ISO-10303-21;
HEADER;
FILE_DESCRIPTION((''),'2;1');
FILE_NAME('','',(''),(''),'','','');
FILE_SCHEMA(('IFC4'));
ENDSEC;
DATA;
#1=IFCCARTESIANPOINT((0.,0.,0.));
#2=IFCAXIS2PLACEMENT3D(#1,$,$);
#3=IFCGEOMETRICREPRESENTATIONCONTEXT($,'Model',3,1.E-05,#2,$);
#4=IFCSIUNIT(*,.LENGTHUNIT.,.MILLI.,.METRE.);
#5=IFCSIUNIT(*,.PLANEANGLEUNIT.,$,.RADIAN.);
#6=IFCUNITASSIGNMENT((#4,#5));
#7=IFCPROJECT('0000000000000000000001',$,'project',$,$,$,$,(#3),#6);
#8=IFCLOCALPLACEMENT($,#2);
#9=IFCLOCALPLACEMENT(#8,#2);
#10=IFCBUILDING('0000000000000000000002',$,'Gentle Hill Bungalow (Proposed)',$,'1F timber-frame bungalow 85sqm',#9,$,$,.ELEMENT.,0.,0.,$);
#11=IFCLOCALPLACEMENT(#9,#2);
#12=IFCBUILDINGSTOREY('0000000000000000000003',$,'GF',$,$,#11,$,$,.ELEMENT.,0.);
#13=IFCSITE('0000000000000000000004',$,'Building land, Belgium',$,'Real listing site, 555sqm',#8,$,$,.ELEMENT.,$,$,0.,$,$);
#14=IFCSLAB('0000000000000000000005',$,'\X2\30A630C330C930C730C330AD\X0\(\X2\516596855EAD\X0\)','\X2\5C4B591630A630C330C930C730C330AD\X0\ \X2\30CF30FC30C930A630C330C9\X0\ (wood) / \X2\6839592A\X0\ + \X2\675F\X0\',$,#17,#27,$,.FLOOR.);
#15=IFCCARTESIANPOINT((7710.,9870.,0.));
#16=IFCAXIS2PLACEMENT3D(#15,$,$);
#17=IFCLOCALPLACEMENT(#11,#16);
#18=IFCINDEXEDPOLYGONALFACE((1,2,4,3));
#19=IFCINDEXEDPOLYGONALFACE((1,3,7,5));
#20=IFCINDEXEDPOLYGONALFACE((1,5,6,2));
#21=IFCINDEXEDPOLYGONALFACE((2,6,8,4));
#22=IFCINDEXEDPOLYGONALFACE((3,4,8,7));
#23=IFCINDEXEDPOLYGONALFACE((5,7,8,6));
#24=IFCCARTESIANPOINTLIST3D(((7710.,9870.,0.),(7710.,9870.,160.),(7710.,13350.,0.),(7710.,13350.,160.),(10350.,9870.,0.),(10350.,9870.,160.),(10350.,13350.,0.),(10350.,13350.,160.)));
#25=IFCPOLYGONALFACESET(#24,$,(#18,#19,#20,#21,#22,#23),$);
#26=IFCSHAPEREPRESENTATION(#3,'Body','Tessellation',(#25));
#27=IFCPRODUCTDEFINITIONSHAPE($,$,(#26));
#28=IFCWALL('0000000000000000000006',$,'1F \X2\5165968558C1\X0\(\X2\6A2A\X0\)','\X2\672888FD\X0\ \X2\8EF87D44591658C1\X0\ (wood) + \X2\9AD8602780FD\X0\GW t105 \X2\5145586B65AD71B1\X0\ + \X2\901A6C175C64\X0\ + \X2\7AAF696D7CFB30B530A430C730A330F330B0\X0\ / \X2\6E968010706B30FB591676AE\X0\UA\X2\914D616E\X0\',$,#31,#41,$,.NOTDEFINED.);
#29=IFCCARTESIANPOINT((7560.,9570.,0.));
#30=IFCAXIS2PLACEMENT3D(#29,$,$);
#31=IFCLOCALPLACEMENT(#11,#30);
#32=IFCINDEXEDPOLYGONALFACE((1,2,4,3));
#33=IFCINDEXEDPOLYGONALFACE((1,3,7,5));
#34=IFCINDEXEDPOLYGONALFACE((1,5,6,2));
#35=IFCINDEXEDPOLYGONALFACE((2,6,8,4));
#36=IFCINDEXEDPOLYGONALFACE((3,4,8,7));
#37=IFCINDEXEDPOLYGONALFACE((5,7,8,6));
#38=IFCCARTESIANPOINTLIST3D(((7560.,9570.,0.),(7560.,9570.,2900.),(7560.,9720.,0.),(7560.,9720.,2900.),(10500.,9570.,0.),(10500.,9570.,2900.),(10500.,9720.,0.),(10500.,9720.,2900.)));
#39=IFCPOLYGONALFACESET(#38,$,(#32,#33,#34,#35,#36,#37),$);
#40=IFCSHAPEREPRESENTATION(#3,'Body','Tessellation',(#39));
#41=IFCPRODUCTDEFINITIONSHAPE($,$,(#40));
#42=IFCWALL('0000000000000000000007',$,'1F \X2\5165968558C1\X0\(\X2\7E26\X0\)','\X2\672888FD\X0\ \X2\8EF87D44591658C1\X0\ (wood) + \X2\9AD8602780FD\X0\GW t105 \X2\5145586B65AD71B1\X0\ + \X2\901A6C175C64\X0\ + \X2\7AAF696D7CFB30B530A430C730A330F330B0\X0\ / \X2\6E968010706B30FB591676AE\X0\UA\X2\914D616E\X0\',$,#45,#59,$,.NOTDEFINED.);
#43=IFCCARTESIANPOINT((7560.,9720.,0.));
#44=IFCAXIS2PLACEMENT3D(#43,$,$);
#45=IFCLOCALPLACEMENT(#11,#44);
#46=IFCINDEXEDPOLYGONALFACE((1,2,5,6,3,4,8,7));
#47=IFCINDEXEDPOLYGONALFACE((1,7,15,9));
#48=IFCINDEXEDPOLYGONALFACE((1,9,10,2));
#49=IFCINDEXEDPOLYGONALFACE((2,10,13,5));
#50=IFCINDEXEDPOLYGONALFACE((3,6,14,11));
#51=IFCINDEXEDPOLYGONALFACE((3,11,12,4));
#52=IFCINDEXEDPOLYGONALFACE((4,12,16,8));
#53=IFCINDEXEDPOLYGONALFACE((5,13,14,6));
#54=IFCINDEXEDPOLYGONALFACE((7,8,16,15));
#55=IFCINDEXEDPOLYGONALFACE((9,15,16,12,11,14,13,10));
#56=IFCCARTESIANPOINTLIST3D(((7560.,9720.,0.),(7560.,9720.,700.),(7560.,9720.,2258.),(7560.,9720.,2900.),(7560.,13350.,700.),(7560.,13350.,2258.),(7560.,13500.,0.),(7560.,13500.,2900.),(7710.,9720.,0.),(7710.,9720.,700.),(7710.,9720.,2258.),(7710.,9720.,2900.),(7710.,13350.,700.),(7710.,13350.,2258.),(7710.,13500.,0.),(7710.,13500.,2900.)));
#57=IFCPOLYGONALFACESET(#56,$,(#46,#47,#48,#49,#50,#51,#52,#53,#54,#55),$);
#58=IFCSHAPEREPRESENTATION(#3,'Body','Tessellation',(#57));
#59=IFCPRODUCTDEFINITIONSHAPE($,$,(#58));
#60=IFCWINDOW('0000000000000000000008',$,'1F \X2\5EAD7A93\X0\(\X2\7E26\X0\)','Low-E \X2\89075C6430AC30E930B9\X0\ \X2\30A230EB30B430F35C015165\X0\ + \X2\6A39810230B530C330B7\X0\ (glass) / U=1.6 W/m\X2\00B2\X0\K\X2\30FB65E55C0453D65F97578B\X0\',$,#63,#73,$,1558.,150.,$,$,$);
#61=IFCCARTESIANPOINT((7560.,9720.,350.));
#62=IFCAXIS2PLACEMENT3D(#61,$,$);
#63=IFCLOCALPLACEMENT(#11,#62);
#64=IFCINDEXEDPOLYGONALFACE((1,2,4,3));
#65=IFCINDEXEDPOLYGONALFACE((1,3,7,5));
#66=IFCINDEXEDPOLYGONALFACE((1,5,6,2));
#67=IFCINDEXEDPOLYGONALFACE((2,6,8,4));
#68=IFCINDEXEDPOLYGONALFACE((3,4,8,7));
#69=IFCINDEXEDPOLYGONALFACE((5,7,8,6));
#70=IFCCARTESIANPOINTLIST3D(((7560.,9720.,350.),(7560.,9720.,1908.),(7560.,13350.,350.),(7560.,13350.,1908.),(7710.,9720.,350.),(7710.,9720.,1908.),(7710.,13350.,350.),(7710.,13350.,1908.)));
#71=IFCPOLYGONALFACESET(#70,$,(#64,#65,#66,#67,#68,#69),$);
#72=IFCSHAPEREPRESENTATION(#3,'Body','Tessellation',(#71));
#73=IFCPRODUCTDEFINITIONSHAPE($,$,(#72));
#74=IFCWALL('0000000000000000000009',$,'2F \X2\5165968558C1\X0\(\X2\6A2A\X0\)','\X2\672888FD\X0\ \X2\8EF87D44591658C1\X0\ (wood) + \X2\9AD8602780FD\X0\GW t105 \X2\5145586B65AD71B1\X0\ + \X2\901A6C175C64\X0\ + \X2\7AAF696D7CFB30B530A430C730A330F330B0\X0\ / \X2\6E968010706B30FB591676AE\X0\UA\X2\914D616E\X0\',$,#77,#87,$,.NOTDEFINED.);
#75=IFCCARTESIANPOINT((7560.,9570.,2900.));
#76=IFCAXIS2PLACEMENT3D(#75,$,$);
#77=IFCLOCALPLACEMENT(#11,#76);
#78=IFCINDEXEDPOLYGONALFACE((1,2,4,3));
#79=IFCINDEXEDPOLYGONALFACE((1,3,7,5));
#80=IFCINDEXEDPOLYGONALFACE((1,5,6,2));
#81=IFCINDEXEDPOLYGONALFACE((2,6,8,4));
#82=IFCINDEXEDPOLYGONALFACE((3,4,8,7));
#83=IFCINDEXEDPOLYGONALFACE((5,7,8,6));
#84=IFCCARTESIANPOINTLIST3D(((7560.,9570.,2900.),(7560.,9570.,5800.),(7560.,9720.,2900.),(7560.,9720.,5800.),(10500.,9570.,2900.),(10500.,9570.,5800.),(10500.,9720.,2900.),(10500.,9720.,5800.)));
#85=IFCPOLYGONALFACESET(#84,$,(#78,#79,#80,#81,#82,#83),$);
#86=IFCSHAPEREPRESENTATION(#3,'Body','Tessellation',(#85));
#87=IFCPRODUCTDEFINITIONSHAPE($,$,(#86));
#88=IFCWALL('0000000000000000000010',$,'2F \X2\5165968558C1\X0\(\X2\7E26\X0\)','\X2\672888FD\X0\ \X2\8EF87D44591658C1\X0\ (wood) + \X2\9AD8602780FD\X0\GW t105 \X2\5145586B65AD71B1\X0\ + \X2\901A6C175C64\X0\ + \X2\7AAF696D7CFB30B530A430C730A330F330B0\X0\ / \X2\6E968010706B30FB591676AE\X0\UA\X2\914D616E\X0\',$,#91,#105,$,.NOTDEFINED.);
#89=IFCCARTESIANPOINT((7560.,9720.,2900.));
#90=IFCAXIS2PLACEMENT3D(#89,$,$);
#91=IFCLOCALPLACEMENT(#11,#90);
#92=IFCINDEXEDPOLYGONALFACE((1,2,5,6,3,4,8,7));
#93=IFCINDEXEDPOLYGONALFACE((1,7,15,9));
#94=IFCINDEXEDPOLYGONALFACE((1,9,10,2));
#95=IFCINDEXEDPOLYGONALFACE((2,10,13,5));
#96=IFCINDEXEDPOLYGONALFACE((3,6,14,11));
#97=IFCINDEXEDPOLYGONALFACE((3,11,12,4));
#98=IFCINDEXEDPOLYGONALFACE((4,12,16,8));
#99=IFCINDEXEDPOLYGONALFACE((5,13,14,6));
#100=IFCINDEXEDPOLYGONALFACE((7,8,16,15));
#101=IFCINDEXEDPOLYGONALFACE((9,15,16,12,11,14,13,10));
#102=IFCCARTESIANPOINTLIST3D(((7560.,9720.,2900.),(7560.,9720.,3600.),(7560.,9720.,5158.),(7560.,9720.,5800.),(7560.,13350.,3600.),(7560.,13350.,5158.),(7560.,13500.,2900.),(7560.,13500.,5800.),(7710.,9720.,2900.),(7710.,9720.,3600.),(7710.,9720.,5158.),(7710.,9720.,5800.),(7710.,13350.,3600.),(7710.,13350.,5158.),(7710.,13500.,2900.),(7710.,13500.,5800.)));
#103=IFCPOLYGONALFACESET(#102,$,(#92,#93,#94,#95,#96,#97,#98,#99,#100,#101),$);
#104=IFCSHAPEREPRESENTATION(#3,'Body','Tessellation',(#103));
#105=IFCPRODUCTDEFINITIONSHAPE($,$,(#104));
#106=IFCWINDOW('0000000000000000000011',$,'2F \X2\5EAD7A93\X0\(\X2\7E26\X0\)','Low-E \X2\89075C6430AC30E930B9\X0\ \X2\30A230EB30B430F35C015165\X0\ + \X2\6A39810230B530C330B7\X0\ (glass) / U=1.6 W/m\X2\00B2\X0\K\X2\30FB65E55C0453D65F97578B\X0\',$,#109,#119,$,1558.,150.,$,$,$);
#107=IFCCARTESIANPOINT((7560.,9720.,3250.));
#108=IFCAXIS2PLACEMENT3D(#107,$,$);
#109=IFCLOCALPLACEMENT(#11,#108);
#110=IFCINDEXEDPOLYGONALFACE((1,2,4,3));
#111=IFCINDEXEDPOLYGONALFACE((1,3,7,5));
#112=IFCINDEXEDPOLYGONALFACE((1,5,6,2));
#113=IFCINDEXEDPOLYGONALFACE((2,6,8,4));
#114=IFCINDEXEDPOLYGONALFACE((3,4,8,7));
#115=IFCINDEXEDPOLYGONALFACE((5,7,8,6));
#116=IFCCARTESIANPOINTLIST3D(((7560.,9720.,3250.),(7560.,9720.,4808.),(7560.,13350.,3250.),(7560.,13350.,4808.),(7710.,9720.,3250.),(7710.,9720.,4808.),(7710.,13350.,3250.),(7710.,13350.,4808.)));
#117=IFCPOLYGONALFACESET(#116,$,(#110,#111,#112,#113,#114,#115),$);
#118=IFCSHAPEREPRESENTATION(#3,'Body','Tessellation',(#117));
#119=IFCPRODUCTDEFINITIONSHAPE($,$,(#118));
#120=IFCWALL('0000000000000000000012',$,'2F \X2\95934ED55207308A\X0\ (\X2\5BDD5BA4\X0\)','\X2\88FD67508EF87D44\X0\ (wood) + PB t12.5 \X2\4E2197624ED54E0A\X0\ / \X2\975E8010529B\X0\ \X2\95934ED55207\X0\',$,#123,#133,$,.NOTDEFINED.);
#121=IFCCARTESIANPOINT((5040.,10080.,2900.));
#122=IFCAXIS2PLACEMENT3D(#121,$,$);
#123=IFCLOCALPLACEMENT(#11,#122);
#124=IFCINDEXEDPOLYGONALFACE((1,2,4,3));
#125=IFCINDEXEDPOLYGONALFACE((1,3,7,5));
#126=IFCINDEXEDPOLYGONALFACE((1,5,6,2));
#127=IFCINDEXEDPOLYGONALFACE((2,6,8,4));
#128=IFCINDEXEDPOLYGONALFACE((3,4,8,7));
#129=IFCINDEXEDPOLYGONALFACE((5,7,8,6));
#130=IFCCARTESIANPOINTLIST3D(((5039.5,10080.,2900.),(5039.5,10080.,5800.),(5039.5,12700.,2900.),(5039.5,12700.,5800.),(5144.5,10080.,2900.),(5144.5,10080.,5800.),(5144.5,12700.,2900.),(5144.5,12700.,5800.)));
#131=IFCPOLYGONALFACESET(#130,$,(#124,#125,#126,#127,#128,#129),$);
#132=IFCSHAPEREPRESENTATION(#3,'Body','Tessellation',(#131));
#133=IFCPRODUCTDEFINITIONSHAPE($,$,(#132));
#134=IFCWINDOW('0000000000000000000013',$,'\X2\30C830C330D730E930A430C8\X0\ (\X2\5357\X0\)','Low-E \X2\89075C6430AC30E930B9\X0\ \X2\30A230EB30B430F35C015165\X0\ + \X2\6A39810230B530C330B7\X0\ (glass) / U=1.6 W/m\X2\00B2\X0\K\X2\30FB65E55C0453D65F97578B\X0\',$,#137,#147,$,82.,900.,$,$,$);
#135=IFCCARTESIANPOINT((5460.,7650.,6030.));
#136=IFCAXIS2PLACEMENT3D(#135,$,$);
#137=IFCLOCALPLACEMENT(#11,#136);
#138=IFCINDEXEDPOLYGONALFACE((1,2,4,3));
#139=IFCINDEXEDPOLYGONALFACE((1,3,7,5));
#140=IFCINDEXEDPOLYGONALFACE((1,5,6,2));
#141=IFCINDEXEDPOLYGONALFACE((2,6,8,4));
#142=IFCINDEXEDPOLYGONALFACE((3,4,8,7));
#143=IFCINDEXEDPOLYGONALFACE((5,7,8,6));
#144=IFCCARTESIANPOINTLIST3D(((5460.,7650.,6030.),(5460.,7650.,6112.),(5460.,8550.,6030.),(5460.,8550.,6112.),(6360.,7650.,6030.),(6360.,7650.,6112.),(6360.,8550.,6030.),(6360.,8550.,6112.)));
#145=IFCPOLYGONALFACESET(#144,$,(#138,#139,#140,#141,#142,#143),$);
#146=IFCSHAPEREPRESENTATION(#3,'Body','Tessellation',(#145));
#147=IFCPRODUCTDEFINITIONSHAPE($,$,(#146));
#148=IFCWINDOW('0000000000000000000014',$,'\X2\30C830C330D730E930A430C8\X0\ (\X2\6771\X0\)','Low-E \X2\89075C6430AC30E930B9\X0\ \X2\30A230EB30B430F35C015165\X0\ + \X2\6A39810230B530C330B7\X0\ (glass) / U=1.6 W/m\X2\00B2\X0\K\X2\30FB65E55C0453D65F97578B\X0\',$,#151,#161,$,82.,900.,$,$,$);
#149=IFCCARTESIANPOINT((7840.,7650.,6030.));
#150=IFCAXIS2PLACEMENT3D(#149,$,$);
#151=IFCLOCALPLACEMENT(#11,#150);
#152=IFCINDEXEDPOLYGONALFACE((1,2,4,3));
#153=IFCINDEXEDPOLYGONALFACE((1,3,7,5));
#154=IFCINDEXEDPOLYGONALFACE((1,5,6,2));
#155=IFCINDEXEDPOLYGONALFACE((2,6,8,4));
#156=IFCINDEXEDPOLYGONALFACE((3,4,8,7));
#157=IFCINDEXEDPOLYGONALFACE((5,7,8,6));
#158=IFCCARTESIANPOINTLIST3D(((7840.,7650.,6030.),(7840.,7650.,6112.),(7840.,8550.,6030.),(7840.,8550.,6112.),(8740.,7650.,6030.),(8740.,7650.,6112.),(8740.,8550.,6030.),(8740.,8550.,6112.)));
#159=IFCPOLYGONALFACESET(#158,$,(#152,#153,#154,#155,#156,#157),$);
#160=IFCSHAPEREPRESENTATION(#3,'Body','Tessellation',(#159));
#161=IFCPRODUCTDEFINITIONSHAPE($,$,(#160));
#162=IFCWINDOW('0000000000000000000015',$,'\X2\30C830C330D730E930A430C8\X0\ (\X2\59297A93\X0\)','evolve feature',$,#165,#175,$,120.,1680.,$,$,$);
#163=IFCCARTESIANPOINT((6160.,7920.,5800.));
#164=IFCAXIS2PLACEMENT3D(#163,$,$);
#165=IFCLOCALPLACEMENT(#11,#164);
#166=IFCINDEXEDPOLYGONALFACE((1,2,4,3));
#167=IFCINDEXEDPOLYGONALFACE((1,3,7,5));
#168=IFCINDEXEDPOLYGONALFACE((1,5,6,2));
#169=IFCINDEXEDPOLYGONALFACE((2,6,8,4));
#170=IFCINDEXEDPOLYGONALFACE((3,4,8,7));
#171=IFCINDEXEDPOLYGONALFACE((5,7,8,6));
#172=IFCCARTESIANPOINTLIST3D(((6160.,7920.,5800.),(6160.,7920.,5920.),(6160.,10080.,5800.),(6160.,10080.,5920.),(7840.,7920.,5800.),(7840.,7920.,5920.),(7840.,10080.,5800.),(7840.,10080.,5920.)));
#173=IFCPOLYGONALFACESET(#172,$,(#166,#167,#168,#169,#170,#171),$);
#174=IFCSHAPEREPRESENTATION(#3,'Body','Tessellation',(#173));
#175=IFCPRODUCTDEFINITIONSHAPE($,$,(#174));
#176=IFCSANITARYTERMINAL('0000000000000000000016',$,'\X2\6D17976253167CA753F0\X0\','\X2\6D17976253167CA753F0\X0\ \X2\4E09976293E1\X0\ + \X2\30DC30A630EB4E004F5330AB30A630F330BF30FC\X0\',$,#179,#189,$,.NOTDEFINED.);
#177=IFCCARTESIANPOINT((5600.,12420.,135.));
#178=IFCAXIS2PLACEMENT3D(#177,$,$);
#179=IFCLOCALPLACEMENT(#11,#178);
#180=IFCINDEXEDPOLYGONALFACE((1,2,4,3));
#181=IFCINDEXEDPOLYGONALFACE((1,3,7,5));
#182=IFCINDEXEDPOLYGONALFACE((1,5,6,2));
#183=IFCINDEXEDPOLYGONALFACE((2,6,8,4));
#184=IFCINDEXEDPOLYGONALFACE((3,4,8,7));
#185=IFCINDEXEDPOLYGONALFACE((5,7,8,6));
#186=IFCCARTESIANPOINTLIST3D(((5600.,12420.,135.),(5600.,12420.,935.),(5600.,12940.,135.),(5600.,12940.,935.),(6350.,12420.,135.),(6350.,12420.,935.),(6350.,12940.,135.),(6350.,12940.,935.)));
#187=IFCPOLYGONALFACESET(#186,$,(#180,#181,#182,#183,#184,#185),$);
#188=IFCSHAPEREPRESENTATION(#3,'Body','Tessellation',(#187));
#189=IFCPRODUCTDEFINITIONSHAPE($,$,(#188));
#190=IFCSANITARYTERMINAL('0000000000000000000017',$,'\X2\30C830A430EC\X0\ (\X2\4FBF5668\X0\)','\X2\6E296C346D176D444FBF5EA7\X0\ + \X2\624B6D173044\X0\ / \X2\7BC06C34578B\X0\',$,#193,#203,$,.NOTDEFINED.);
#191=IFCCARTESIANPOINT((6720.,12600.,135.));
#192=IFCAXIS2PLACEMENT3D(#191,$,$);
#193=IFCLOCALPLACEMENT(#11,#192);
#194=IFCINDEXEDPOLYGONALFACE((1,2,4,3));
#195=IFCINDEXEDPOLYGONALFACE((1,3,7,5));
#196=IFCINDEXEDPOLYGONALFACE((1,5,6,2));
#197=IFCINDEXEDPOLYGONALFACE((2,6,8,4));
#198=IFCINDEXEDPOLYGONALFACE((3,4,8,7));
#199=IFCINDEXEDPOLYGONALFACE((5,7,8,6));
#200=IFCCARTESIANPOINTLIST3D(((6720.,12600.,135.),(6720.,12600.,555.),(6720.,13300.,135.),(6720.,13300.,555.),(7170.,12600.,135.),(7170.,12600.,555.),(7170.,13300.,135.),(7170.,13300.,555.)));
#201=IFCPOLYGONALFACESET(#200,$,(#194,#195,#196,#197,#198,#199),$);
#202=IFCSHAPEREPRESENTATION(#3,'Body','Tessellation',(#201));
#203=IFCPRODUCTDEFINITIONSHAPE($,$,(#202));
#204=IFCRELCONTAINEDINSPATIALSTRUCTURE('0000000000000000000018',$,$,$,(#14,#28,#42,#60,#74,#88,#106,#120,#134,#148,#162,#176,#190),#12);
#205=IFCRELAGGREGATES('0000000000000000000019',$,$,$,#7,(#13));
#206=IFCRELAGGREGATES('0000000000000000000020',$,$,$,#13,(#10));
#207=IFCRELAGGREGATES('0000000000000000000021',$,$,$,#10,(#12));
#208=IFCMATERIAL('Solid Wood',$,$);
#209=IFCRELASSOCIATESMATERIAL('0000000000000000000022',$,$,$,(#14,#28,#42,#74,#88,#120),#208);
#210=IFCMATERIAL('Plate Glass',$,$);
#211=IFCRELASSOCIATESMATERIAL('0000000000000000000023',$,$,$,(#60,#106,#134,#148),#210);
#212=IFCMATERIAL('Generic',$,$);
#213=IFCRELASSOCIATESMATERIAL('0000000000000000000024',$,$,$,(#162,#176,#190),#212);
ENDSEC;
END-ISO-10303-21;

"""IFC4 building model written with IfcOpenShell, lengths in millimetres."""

from ifc_helpers import new_model, si_unit, frame, frame_2d, origin, place, context, project, spatial, rectangle, extrude, material, element, fill, save


model = new_model("IFC4")

# Units and contexts
model_context = context("Model", 3, precision=1e-05, world=origin())
ifc_project = project(units=[si_unit("LENGTHUNIT", "METRE", prefix="MILLI"), si_unit("PLANEANGLEUNIT", "RADIAN")], contexts=[model_context])

# Site, building, storey
site_placement = place(None, origin())
site = spatial("IfcSite", under=ifc_project, at=site_placement, Name="Building land, Belgium", ObjectType="Real listing site, 555sqm", CompositionType="ELEMENT", RefElevation=0.0)
building_placement = place(site_placement, origin())
building = spatial("IfcBuilding", under=site, at=building_placement, Name="Gentle Hill Bungalow (Proposed)", ObjectType="1F timber-frame bungalow 85sqm", CompositionType="ELEMENT", ElevationOfRefHeight=0.0, ElevationOfTerrain=0.0)
storey_placement = place(building_placement, origin())
storey = spatial("IfcBuildingStorey", under=building, at=storey_placement, Name="GF", CompositionType="ELEMENT", Elevation=0.0)

# Slab
ifc_material_1 = material(Name="Solid Wood")
slab_placement = place(storey_placement, frame((7710.0, 9870.0, 0.0)))
element("IfcSlab", 1, at=slab_placement, inside=storey, material=ifc_material_1, Name="ウッドデッキ(入隅庭)", Description="屋外ウッドデッキ ハードウッド (wood) / 根太 + 束", PredefinedType="FLOOR", context=model_context, shape_type="SweptSolid", body=[
    extrude(rectangle(XDim=2640.0, YDim=3480.0, at=frame_2d((1320.0, 1740.0))), frame((7710.0, 9870.0, 0.0)), (0.0, 0.0, 1.0), 160.0),
])

# Wall
wall_1_placement = place(storey_placement, frame((7560.0, 9570.0, 0.0)))
element("IfcWall", 2, at=wall_1_placement, inside=storey, material=ifc_material_1, Name="1F 入隅壁(横)", Description="木製 軸組外壁 (wood) + 高性能GW t105 充填断熱 + 通気層 + 窯業系サイディング / 準耐火・外皮UA配慮", PredefinedType="NOTDEFINED", context=model_context, shape_type="SweptSolid", body=[
    extrude(rectangle(XDim=2940.0, YDim=150.0, at=frame_2d((1470.0, 75.0))), frame((7560.0, 9570.0, 0.0)), (0.0, 0.0, 1.0), 2900.0),
])

# Wall, opening, window
wall_2_placement = place(storey_placement, frame((7560.0, 9720.0, 0.0)))
wall_2 = element("IfcWall", 3, at=wall_2_placement, inside=storey, material=ifc_material_1, Name="1F 入隅壁(縦)", Description="木製 軸組外壁 (wood) + 高性能GW t105 充填断熱 + 通気層 + 窯業系サイディング / 準耐火・外皮UA配慮", PredefinedType="NOTDEFINED", context=model_context, shape_type="SweptSolid", body=[
    extrude(rectangle(XDim=150.0, YDim=3780.0, at=frame_2d((75.0, 1890.0))), frame((7560.0, 9720.0, 0.0)), (0.0, 0.0, 1.0), 2900.0),
])
opening_1_placement = place(storey_placement, frame((7560.0, 9720.0, 350.0)))
opening_1 = element("IfcOpeningElement", 4, at=opening_1_placement, cuts=wall_2, PredefinedType="NOTDEFINED", context=model_context, shape_type="SweptSolid", body=[
    extrude(rectangle(XDim=150.0, YDim=3630.0, at=frame_2d((75.0, 1815.0))), frame((7560.0, 9720.0, 350.0)), (0.0, 0.0, 1.0), 1558.0),
])
ifc_material_2 = material(Name="Plate Glass")
window_1_placement = place(storey_placement, frame((7560.0, 9720.0, 350.0)))
window_1 = element("IfcWindow", 5, at=window_1_placement, inside=storey, material=ifc_material_2, Name="1F 庭窓(縦)", Description="Low-E 複層ガラス アルゴン封入 + 樹脂サッシ (glass) / U=1.6 W/m²K・日射取得型", OverallHeight=1558.0, OverallWidth=150.0, context=model_context, shape_type="SweptSolid", body=[
    extrude(rectangle(XDim=150.0, YDim=3630.0, at=frame_2d((75.0, 1815.0))), frame((7560.0, 9720.0, 350.0)), (0.0, 0.0, 1.0), 1558.0),
])
fill(opening_1, window_1)

# Wall
wall_3_placement = place(storey_placement, frame((7560.0, 9570.0, 2900.0)))
element("IfcWall", 6, at=wall_3_placement, inside=storey, material=ifc_material_1, Name="2F 入隅壁(横)", Description="木製 軸組外壁 (wood) + 高性能GW t105 充填断熱 + 通気層 + 窯業系サイディング / 準耐火・外皮UA配慮", PredefinedType="NOTDEFINED", context=model_context, shape_type="SweptSolid", body=[
    extrude(rectangle(XDim=2940.0, YDim=150.0, at=frame_2d((1470.0, 75.0))), frame((7560.0, 9570.0, 2900.0)), (0.0, 0.0, 1.0), 2900.0),
])

# Wall, opening, window
wall_4_placement = place(storey_placement, frame((7560.0, 9720.0, 2900.0)))
wall_4 = element("IfcWall", 7, at=wall_4_placement, inside=storey, material=ifc_material_1, Name="2F 入隅壁(縦)", Description="木製 軸組外壁 (wood) + 高性能GW t105 充填断熱 + 通気層 + 窯業系サイディング / 準耐火・外皮UA配慮", PredefinedType="NOTDEFINED", context=model_context, shape_type="SweptSolid", body=[
    extrude(rectangle(XDim=150.0, YDim=3780.0, at=frame_2d((75.0, 1890.0))), frame((7560.0, 9720.0, 2900.0)), (0.0, 0.0, 1.0), 2900.0),
])
opening_2_placement = place(storey_placement, frame((7560.0, 9720.0, 3250.0)))
opening_2 = element("IfcOpeningElement", 8, at=opening_2_placement, cuts=wall_4, PredefinedType="NOTDEFINED", context=model_context, shape_type="SweptSolid", body=[
    extrude(rectangle(XDim=150.0, YDim=3630.0, at=frame_2d((75.0, 1815.0))), frame((7560.0, 9720.0, 3250.0)), (0.0, 0.0, 1.0), 1558.0),
])
window_2_placement = place(storey_placement, frame((7560.0, 9720.0, 3250.0)))
window_2 = element("IfcWindow", 9, at=window_2_placement, inside=storey, material=ifc_material_2, Name="2F 庭窓(縦)", Description="Low-E 複層ガラス アルゴン封入 + 樹脂サッシ (glass) / U=1.6 W/m²K・日射取得型", OverallHeight=1558.0, OverallWidth=150.0, context=model_context, shape_type="SweptSolid", body=[
    extrude(rectangle(XDim=150.0, YDim=3630.0, at=frame_2d((75.0, 1815.0))), frame((7560.0, 9720.0, 3250.0)), (0.0, 0.0, 1.0), 1558.0),
])
fill(opening_2, window_2)

# Wall
wall_5_placement = place(storey_placement, frame((5040.0, 10080.0, 2900.0)))
element("IfcWall", 10, at=wall_5_placement, inside=storey, material=ifc_material_1, Name="2F 間仕切り (寝室)", Description="製材軸組 (wood) + PB t12.5 両面仕上 / 非耐力 間仕切", PredefinedType="NOTDEFINED", context=model_context, shape_type="SweptSolid", body=[
    extrude(rectangle(XDim=105.0, YDim=2620.0, at=frame_2d((52.0, 1310.0))), frame((5040.0, 10080.0, 2900.0)), (0.0, 0.0, 1.0), 2900.0),
])

# Windows
window_3_placement = place(storey_placement, frame((5460.0, 7650.0, 6030.0)))
element("IfcWindow", 11, at=window_3_placement, inside=storey, material=ifc_material_2, Name="トップライト (南)", Description="Low-E 複層ガラス アルゴン封入 + 樹脂サッシ (glass) / U=1.6 W/m²K・日射取得型", OverallHeight=82.0, OverallWidth=900.0, context=model_context, shape_type="SweptSolid", body=[
    extrude(rectangle(XDim=900.0, YDim=900.0, at=frame_2d((450.0, 450.0))), frame((5460.0, 7650.0, 6030.0)), (0.0, 0.0, 1.0), 82.0),
])
window_4_placement = place(storey_placement, frame((7840.0, 7650.0, 6030.0)))
element("IfcWindow", 12, at=window_4_placement, inside=storey, material=ifc_material_2, Name="トップライト (東)", Description="Low-E 複層ガラス アルゴン封入 + 樹脂サッシ (glass) / U=1.6 W/m²K・日射取得型", OverallHeight=82.0, OverallWidth=900.0, context=model_context, shape_type="SweptSolid", body=[
    extrude(rectangle(XDim=900.0, YDim=900.0, at=frame_2d((450.0, 450.0))), frame((7840.0, 7650.0, 6030.0)), (0.0, 0.0, 1.0), 82.0),
])
ifc_material_3 = material(Name="Generic")
window_5_placement = place(storey_placement, frame((6160.0, 7920.0, 5800.0)))
element("IfcWindow", 13, at=window_5_placement, inside=storey, material=ifc_material_3, Name="トップライト (天窓)", Description="evolve feature", OverallHeight=120.0, OverallWidth=1680.0, context=model_context, shape_type="SweptSolid", body=[
    extrude(rectangle(XDim=1680.0, YDim=2160.0, at=frame_2d((840.0, 1080.0))), frame((6160.0, 7920.0, 5800.0)), (0.0, 0.0, 1.0), 120.0),
])

# Sanitary terminals
sanitary_terminal_1_placement = place(storey_placement, frame((5600.0, 12420.0, 135.0)))
element("IfcSanitaryTerminal", 14, at=sanitary_terminal_1_placement, inside=storey, material=ifc_material_3, Name="洗面化粧台", Description="洗面化粧台 三面鏡 + ボウル一体カウンター", PredefinedType="NOTDEFINED", context=model_context, shape_type="SweptSolid", body=[
    extrude(rectangle(XDim=750.0, YDim=520.0, at=frame_2d((375.0, 260.0))), frame((5600.0, 12420.0, 135.0)), (0.0, 0.0, 1.0), 800.0),
])
sanitary_terminal_2_placement = place(storey_placement, frame((6720.0, 12600.0, 135.0)))
element("IfcSanitaryTerminal", 15, at=sanitary_terminal_2_placement, inside=storey, material=ifc_material_3, Name="トイレ (便器)", Description="温水洗浄便座 + 手洗い / 節水型", PredefinedType="NOTDEFINED", context=model_context, shape_type="SweptSolid", body=[
    extrude(rectangle(XDim=450.0, YDim=700.0, at=frame_2d((225.0, 350.0))), frame((6720.0, 12600.0, 135.0)), (0.0, 0.0, 1.0), 420.0),
])

save(model, "model.ifc")
